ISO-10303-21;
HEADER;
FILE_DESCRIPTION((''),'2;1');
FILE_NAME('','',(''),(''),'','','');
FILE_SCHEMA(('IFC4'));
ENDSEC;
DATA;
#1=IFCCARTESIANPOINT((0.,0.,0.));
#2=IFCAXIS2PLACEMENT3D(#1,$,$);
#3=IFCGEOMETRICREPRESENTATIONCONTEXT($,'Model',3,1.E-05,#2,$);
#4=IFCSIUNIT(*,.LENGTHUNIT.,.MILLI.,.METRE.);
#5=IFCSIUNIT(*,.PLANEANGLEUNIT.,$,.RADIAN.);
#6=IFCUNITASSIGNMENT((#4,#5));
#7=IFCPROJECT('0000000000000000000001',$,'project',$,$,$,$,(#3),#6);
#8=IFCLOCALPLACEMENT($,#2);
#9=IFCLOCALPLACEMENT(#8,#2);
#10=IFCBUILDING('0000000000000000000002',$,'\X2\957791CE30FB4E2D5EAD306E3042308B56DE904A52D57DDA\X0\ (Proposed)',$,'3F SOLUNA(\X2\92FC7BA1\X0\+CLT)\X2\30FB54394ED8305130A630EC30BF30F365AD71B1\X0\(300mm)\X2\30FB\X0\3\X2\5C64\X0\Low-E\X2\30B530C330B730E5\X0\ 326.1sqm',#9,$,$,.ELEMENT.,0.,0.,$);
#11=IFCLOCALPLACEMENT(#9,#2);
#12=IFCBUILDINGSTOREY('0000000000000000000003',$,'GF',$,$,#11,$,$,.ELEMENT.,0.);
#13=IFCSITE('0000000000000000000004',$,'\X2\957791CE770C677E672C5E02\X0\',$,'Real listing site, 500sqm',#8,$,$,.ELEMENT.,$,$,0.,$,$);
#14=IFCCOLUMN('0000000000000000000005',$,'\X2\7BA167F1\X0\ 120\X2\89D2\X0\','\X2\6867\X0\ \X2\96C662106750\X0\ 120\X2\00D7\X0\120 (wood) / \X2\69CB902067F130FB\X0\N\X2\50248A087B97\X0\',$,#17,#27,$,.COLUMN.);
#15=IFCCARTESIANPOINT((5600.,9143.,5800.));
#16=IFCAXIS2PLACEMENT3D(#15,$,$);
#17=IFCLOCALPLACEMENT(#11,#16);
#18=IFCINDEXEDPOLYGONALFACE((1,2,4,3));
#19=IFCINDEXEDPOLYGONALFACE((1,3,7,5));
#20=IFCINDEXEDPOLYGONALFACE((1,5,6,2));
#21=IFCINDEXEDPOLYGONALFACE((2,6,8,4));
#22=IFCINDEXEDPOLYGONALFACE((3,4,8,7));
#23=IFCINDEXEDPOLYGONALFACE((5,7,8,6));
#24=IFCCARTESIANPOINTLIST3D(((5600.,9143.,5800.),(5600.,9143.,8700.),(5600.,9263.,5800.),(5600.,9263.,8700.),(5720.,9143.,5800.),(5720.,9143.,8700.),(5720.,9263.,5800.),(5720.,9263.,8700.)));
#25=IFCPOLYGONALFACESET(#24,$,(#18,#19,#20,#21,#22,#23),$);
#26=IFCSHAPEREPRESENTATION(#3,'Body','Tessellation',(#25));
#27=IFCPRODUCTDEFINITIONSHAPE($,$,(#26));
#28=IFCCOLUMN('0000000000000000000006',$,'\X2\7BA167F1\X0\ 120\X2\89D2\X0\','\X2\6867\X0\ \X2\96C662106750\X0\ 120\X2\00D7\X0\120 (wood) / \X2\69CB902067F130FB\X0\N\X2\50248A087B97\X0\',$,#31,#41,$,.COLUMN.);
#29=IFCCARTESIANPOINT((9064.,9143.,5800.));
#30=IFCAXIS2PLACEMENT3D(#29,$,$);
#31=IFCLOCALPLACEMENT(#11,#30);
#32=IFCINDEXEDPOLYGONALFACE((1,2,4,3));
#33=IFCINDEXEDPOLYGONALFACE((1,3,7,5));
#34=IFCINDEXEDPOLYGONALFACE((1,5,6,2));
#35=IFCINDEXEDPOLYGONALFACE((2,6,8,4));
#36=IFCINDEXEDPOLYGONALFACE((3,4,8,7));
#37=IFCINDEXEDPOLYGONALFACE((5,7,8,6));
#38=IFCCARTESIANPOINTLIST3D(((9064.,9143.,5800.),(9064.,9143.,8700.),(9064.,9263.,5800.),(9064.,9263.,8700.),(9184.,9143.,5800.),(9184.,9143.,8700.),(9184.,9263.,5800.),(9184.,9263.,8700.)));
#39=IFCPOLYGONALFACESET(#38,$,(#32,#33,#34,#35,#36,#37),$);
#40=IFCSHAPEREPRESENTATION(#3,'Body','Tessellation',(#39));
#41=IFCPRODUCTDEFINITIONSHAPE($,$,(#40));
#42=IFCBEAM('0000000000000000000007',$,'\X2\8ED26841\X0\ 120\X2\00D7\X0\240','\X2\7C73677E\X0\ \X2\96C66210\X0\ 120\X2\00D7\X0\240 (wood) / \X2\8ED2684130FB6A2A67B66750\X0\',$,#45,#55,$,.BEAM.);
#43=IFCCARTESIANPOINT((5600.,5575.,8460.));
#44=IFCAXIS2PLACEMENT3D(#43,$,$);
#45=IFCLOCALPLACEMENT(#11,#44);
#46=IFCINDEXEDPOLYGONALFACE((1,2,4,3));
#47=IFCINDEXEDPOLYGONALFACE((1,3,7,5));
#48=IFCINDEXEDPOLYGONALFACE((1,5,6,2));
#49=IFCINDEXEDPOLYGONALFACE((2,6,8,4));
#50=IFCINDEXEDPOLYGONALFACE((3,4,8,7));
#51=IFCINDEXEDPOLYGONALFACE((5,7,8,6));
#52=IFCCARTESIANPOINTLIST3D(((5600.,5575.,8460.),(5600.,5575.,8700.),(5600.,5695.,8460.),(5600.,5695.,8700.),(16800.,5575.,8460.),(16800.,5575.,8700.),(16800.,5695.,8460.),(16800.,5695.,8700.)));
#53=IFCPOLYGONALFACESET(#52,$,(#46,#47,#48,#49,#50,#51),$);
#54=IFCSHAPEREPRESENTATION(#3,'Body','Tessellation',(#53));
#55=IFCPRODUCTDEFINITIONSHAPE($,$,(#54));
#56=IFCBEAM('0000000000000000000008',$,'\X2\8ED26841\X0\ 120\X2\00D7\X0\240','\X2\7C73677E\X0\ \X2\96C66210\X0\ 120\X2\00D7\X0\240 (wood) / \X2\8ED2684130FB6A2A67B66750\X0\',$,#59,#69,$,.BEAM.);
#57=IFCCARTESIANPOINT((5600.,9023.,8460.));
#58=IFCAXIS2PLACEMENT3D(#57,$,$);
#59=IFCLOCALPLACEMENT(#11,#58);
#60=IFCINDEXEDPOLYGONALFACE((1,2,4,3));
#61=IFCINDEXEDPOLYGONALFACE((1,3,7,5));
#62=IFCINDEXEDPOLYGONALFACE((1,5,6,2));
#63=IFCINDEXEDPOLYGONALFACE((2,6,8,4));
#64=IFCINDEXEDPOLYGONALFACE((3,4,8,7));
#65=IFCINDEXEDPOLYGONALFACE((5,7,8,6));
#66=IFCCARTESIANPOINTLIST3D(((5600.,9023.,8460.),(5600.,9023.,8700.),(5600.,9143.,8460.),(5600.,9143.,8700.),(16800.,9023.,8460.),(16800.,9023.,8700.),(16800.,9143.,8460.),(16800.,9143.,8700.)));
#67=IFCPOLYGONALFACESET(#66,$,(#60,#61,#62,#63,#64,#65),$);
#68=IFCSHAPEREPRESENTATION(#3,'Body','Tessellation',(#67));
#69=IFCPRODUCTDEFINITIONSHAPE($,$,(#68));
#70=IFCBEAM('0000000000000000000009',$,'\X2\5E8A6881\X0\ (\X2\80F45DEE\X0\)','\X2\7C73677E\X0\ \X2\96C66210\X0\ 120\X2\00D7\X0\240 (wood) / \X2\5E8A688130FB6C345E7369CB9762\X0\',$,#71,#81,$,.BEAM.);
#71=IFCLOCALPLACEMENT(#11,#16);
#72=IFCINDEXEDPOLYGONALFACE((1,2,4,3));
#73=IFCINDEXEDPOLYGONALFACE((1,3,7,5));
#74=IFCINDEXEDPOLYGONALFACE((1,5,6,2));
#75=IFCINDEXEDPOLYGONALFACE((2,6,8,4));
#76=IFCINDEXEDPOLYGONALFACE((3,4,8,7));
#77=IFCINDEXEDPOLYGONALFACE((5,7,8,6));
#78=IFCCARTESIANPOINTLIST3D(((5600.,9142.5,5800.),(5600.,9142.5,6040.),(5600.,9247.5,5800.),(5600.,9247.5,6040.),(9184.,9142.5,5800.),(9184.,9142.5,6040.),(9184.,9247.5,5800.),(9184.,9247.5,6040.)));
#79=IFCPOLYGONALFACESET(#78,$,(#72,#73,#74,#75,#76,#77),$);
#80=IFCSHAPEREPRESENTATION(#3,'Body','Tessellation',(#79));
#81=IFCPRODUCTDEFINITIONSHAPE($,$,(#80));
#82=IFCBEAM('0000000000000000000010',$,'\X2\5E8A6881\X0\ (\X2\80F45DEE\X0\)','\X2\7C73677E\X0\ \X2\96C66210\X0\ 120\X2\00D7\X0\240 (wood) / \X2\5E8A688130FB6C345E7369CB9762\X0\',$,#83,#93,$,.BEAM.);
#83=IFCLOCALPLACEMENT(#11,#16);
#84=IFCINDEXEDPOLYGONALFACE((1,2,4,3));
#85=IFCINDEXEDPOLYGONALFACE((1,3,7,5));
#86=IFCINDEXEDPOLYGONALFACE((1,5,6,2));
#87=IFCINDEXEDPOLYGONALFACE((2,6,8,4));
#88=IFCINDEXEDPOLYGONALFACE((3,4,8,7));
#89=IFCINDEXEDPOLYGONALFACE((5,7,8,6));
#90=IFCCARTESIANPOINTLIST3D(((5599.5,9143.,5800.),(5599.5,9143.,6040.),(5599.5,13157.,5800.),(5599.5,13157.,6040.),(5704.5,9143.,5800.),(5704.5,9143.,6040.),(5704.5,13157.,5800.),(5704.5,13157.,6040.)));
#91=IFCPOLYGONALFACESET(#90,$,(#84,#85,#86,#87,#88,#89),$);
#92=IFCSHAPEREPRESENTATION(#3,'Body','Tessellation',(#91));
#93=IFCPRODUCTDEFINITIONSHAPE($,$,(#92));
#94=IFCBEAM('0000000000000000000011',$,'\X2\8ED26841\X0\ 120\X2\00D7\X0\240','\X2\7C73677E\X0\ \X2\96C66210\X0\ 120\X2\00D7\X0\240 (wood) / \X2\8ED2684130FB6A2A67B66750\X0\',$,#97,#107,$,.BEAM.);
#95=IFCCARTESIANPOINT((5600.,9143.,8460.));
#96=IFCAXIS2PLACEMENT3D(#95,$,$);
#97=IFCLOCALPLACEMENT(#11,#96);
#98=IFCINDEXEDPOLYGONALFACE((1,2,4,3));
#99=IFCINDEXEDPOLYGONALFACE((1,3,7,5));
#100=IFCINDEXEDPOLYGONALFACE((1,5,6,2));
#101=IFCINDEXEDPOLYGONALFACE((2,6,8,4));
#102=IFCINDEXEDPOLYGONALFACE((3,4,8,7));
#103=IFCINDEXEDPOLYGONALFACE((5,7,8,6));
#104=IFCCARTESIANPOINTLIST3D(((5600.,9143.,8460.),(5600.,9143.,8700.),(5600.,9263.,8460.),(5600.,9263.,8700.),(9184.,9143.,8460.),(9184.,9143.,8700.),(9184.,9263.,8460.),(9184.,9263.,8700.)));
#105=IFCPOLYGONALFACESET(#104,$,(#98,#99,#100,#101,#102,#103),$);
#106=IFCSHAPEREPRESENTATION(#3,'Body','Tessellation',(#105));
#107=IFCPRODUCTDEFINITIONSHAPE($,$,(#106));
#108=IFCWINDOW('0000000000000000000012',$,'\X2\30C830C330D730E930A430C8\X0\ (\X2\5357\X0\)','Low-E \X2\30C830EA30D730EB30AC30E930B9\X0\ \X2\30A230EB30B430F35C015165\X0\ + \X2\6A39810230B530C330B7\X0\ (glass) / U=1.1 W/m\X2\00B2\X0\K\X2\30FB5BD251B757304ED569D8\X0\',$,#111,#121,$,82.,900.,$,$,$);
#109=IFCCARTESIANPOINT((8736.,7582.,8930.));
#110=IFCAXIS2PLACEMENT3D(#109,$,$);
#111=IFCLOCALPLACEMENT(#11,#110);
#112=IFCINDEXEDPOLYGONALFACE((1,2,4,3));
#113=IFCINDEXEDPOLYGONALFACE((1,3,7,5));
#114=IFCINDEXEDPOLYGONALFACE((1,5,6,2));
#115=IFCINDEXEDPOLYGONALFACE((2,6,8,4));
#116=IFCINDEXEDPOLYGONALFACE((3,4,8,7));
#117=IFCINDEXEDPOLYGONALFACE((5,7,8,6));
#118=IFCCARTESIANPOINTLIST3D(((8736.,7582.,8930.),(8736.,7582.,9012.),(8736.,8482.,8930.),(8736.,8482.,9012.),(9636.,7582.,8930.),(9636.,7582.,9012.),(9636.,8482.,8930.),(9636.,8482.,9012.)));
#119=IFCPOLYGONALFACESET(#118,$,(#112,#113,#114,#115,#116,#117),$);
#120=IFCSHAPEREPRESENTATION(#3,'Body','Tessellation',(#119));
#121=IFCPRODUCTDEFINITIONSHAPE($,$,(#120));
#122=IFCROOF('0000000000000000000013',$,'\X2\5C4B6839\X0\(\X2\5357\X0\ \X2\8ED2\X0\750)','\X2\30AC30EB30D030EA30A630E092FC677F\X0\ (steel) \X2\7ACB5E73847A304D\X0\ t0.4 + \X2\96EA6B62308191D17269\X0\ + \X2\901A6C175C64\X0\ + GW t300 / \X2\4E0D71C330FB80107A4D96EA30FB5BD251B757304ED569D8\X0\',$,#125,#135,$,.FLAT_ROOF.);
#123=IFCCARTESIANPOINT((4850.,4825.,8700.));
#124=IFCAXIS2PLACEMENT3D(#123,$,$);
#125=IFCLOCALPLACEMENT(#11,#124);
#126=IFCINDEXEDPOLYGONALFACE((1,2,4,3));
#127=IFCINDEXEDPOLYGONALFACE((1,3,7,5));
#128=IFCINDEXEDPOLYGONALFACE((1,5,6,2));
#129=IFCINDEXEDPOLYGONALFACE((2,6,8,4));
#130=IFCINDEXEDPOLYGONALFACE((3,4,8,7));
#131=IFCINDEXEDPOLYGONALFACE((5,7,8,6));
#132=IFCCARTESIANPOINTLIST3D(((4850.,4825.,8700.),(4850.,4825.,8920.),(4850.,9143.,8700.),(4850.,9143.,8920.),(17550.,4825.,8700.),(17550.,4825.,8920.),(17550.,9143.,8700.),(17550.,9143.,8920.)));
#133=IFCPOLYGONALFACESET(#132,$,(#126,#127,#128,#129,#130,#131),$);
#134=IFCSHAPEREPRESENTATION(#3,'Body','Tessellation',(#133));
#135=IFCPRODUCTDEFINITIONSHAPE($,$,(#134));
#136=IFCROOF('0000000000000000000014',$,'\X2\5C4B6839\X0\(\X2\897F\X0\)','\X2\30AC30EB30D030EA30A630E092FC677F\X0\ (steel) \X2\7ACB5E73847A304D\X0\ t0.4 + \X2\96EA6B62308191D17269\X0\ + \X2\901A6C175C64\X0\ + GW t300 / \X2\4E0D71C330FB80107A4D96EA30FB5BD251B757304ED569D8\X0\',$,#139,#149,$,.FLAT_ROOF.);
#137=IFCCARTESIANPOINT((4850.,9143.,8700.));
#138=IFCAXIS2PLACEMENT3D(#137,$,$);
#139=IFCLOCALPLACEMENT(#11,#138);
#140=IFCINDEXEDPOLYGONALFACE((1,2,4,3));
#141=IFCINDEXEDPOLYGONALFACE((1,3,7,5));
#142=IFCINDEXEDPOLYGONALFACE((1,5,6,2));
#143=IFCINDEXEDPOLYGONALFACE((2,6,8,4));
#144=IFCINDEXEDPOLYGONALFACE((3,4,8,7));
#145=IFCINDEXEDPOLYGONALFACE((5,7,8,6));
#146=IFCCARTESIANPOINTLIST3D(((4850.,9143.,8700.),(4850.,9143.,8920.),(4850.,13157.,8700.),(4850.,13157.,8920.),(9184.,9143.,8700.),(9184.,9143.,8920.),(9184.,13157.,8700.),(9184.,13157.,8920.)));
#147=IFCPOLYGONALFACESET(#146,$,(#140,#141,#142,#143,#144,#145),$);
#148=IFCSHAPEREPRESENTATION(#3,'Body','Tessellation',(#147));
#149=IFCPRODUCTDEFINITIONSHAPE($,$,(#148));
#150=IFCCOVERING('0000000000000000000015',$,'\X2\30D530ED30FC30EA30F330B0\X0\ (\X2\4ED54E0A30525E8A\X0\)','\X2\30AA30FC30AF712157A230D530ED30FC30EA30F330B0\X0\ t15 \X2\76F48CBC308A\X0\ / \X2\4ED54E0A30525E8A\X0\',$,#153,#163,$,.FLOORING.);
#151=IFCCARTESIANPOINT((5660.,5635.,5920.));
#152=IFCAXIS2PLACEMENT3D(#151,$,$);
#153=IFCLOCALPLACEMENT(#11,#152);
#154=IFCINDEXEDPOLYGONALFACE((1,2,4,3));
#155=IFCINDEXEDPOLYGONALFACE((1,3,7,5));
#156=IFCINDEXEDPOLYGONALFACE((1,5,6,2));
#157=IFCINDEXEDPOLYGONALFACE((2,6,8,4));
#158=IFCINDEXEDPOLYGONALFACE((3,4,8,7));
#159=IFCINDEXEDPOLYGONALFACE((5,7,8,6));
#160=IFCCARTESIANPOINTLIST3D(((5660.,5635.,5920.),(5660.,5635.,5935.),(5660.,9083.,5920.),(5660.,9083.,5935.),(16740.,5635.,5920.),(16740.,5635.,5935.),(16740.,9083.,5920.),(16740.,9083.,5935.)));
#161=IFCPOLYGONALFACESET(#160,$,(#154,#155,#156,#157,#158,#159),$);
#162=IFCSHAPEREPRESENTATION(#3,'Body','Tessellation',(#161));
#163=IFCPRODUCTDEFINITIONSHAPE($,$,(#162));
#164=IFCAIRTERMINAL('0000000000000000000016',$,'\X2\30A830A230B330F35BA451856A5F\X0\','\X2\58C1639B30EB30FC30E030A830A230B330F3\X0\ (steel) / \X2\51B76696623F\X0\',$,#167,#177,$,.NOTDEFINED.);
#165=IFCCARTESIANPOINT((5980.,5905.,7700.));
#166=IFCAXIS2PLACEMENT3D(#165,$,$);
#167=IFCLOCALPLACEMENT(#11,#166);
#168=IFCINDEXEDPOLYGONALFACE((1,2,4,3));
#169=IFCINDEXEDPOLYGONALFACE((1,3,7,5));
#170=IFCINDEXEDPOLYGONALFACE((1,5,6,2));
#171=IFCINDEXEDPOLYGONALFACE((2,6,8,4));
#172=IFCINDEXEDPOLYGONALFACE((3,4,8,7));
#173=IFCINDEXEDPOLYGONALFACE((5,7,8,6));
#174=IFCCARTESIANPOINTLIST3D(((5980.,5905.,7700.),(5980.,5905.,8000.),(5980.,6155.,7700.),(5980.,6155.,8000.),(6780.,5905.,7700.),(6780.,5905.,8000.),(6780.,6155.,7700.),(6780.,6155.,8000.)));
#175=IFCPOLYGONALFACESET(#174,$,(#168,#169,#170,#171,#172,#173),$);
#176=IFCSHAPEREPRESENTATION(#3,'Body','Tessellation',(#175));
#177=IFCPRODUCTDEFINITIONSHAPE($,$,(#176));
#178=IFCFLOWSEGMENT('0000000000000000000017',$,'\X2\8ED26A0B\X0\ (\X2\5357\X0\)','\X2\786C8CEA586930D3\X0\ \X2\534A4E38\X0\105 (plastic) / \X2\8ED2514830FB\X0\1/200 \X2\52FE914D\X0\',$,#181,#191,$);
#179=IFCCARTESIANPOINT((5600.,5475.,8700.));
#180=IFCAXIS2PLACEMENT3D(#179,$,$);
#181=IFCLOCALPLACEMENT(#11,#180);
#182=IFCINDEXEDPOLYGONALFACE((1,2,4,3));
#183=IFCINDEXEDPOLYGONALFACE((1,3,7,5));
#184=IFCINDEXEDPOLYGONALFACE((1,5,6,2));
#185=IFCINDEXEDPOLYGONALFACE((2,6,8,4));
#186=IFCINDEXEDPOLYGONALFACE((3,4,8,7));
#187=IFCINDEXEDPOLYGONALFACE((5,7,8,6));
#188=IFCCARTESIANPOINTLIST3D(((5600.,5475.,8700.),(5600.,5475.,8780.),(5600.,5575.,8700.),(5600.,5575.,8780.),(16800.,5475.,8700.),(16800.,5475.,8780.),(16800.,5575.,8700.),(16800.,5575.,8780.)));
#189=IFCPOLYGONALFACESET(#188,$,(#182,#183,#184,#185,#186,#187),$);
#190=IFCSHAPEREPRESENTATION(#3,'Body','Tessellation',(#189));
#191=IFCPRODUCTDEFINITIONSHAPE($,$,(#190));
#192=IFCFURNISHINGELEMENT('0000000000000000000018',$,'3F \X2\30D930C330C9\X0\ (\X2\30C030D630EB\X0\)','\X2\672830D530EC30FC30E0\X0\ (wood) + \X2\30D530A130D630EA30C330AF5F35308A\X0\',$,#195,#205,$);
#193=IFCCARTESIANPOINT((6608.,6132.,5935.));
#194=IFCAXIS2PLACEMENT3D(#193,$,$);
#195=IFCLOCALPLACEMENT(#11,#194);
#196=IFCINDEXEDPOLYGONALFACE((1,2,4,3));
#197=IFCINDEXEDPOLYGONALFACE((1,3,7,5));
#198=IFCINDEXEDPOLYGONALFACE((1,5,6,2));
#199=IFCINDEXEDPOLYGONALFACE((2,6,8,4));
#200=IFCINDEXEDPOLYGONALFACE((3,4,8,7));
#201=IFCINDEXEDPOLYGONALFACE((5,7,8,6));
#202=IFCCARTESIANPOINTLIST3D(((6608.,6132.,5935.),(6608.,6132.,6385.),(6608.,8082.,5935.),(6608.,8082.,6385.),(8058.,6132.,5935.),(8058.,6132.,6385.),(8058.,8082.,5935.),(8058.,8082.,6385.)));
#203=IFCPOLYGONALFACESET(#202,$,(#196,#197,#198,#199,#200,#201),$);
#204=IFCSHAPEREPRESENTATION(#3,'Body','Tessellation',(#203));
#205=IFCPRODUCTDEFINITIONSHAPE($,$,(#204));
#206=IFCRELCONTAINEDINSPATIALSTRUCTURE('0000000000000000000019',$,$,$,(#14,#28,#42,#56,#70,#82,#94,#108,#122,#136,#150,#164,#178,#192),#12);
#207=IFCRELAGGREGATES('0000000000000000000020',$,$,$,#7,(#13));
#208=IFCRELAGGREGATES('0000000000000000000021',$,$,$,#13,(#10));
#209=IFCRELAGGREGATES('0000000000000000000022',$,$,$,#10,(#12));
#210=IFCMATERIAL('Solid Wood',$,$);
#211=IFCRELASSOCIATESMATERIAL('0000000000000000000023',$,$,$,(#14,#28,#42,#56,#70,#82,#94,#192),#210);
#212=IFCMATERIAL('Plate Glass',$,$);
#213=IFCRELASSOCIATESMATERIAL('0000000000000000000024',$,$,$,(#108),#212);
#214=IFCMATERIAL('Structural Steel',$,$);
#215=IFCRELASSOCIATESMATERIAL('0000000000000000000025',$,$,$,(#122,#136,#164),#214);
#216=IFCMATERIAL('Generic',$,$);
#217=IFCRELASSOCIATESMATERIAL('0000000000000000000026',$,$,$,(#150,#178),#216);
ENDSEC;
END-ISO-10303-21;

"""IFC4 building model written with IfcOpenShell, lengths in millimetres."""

from ifc_helpers import new_model, si_unit, frame, frame_2d, origin, place, context, project, spatial, rectangle, extrude, material, element, save


model = new_model("IFC4")

# Units and contexts
model_context = context("Model", 3, precision=1e-05, world=origin())
ifc_project = project(units=[si_unit("LENGTHUNIT", "METRE", prefix="MILLI"), si_unit("PLANEANGLEUNIT", "RADIAN")], contexts=[model_context])

# Site, building, storey
site_placement = place(None, origin())
site = spatial("IfcSite", under=ifc_project, at=site_placement, Name="長野県松本市", ObjectType="Real listing site, 500sqm", CompositionType="ELEMENT", RefElevation=0.0)
building_placement = place(site_placement, origin())
building = spatial("IfcBuilding", under=site, at=building_placement, Name="長野・中庭のある回遊動線 (Proposed)", ObjectType="3F SOLUNA(鋼管+CLT)・吹付けウレタン断熱(300mm)・3層Low-Eサッシュ 326.1sqm", CompositionType="ELEMENT", ElevationOfRefHeight=0.0, ElevationOfTerrain=0.0)
storey_placement = place(building_placement, origin())
storey = spatial("IfcBuildingStorey", under=building, at=storey_placement, Name="GF", CompositionType="ELEMENT", Elevation=0.0)

# Columns
ifc_material_1 = material(Name="Solid Wood")
column_1_placement = place(storey_placement, frame((5600.0, 9143.0, 5800.0)))
element("IfcColumn", 1, at=column_1_placement, inside=storey, material=ifc_material_1, Name="管柱 120角", Description="桧 集成材 120×120 (wood) / 構造柱・N値計算", PredefinedType="COLUMN", context=model_context, shape_type="SweptSolid", body=[
    extrude(rectangle(XDim=120.0, YDim=120.0, at=frame_2d((60.0, 60.0))), frame((5600.0, 9143.0, 5800.0)), (0.0, 0.0, 1.0), 2900.0),
])
column_2_placement = place(storey_placement, frame((9064.0, 9143.0, 5800.0)))
element("IfcColumn", 2, at=column_2_placement, inside=storey, material=ifc_material_1, Name="管柱 120角", Description="桧 集成材 120×120 (wood) / 構造柱・N値計算", PredefinedType="COLUMN", context=model_context, shape_type="SweptSolid", body=[
    extrude(rectangle(XDim=120.0, YDim=120.0, at=frame_2d((60.0, 60.0))), frame((9064.0, 9143.0, 5800.0)), (0.0, 0.0, 1.0), 2900.0),
])

# Beams
beam_1_placement = place(storey_placement, frame((5600.0, 5575.0, 8460.0)))
element("IfcBeam", 3, at=beam_1_placement, inside=storey, material=ifc_material_1, Name="軒桁 120×240", Description="米松 集成 120×240 (wood) / 軒桁・横架材", PredefinedType="BEAM", context=model_context, shape_type="SweptSolid", body=[
    extrude(rectangle(XDim=11200.0, YDim=120.0, at=frame_2d((5600.0, 60.0))), frame((5600.0, 5575.0, 8460.0)), (0.0, 0.0, 1.0), 240.0),
])
beam_2_placement = place(storey_placement, frame((5600.0, 9023.0, 8460.0)))
element("IfcBeam", 4, at=beam_2_placement, inside=storey, material=ifc_material_1, Name="軒桁 120×240", Description="米松 集成 120×240 (wood) / 軒桁・横架材", PredefinedType="BEAM", context=model_context, shape_type="SweptSolid", body=[
    extrude(rectangle(XDim=11200.0, YDim=120.0, at=frame_2d((5600.0, 60.0))), frame((5600.0, 9023.0, 8460.0)), (0.0, 0.0, 1.0), 240.0),
])
beam_3_placement = place(storey_placement, frame((5600.0, 9143.0, 5800.0)))
element("IfcBeam", 5, at=beam_3_placement, inside=storey, material=ifc_material_1, Name="床梁 (胴差)", Description="米松 集成 120×240 (wood) / 床梁・水平構面", PredefinedType="BEAM", context=model_context, shape_type="SweptSolid", body=[
    extrude(rectangle(XDim=3584.0, YDim=105.0, at=frame_2d((1792.0, 52.0))), frame((5600.0, 9143.0, 5800.0)), (0.0, 0.0, 1.0), 240.0),
])
beam_4_placement = place(storey_placement, frame((5600.0, 9143.0, 5800.0)))
element("IfcBeam", 6, at=beam_4_placement, inside=storey, material=ifc_material_1, Name="床梁 (胴差)", Description="米松 集成 120×240 (wood) / 床梁・水平構面", PredefinedType="BEAM", context=model_context, shape_type="SweptSolid", body=[
    extrude(rectangle(XDim=105.0, YDim=4014.0, at=frame_2d((52.0, 2007.0))), frame((5600.0, 9143.0, 5800.0)), (0.0, 0.0, 1.0), 240.0),
])
beam_5_placement = place(storey_placement, frame((5600.0, 9143.0, 8460.0)))
element("IfcBeam", 7, at=beam_5_placement, inside=storey, material=ifc_material_1, Name="軒桁 120×240", Description="米松 集成 120×240 (wood) / 軒桁・横架材", PredefinedType="BEAM", context=model_context, shape_type="SweptSolid", body=[
    extrude(rectangle(XDim=3584.0, YDim=120.0, at=frame_2d((1792.0, 60.0))), frame((5600.0, 9143.0, 8460.0)), (0.0, 0.0, 1.0), 240.0),
])

# Window
ifc_material_2 = material(Name="Plate Glass")
window_placement = place(storey_placement, frame((8736.0, 7582.0, 8930.0)))
element("IfcWindow", 8, at=window_placement, inside=storey, material=ifc_material_2, Name="トップライト (南)", Description="Low-E トリプルガラス アルゴン封入 + 樹脂サッシ (glass) / U=1.1 W/m²K・寒冷地仕様", OverallHeight=82.0, OverallWidth=900.0, context=model_context, shape_type="SweptSolid", body=[
    extrude(rectangle(XDim=900.0, YDim=900.0, at=frame_2d((450.0, 450.0))), frame((8736.0, 7582.0, 8930.0)), (0.0, 0.0, 1.0), 82.0),
])

# Roofs
ifc_material_3 = material(Name="Structural Steel")
roof_1_placement = place(storey_placement, frame((4850.0, 4825.0, 8700.0)))
element("IfcRoof", 9, at=roof_1_placement, inside=storey, material=ifc_material_3, Name="屋根(南 軒750)", Description="ガルバリウム鋼板 (steel) 立平葺き t0.4 + 雪止め金物 + 通気層 + GW t300 / 不燃・耐積雪・寒冷地仕様", PredefinedType="FLAT_ROOF", context=model_context, shape_type="SweptSolid", body=[
    extrude(rectangle(XDim=12700.0, YDim=4318.0, at=frame_2d((6350.0, 2159.0))), frame((4850.0, 4825.0, 8700.0)), (0.0, 0.0, 1.0), 220.0),
])
roof_2_placement = place(storey_placement, frame((4850.0, 9143.0, 8700.0)))
element("IfcRoof", 10, at=roof_2_placement, inside=storey, material=ifc_material_3, Name="屋根(西)", Description="ガルバリウム鋼板 (steel) 立平葺き t0.4 + 雪止め金物 + 通気層 + GW t300 / 不燃・耐積雪・寒冷地仕様", PredefinedType="FLAT_ROOF", context=model_context, shape_type="SweptSolid", body=[
    extrude(rectangle(XDim=4334.0, YDim=4014.0, at=frame_2d((2167.0, 2007.0))), frame((4850.0, 9143.0, 8700.0)), (0.0, 0.0, 1.0), 220.0),
])

# Covering
ifc_material_4 = material(Name="Generic")
covering_placement = place(storey_placement, frame((5660.0, 5635.0, 5920.0)))
element("IfcCovering", 11, at=covering_placement, inside=storey, material=ifc_material_4, Name="フローリング (仕上げ床)", Description="オーク無垢フローリング t15 直貼り / 仕上げ床", PredefinedType="FLOORING", context=model_context, shape_type="SweptSolid", body=[
    extrude(rectangle(XDim=11080.0, YDim=3448.0, at=frame_2d((5540.0, 1724.0))), frame((5660.0, 5635.0, 5920.0)), (0.0, 0.0, 1.0), 15.0),
])

# Air terminal
air_terminal_placement = place(storey_placement, frame((5980.0, 5905.0, 7700.0)))
element("IfcAirTerminal", 12, at=air_terminal_placement, inside=storey, material=ifc_material_3, Name="エアコン室内機", Description="壁掛ルームエアコン (steel) / 冷暖房", PredefinedType="NOTDEFINED", context=model_context, shape_type="SweptSolid", body=[
    extrude(rectangle(XDim=800.0, YDim=250.0, at=frame_2d((400.0, 125.0))), frame((5980.0, 5905.0, 7700.0)), (0.0, 0.0, 1.0), 300.0),
])

# Flow segment
flow_segment_placement = place(storey_placement, frame((5600.0, 5475.0, 8700.0)))
element("IfcFlowSegment", 13, at=flow_segment_placement, inside=storey, material=ifc_material_4, Name="軒樋 (南)", Description="硬質塩ビ 半丸105 (plastic) / 軒先・1/200 勾配", context=model_context, shape_type="SweptSolid", body=[
    extrude(rectangle(XDim=11200.0, YDim=100.0, at=frame_2d((5600.0, 50.0))), frame((5600.0, 5475.0, 8700.0)), (0.0, 0.0, 1.0), 80.0),
])

# Furnishing element
furnishing_placement = place(storey_placement, frame((6608.0, 6132.0, 5935.0)))
element("IfcFurnishingElement", 14, at=furnishing_placement, inside=storey, material=ifc_material_1, Name="3F ベッド (ダブル)", Description="木フレーム (wood) + ファブリック張り", context=model_context, shape_type="SweptSolid", body=[
    extrude(rectangle(XDim=1450.0, YDim=1950.0, at=frame_2d((725.0, 975.0))), frame((6608.0, 6132.0, 5935.0)), (0.0, 0.0, 1.0), 450.0),
])

save(model, "model.ifc")
